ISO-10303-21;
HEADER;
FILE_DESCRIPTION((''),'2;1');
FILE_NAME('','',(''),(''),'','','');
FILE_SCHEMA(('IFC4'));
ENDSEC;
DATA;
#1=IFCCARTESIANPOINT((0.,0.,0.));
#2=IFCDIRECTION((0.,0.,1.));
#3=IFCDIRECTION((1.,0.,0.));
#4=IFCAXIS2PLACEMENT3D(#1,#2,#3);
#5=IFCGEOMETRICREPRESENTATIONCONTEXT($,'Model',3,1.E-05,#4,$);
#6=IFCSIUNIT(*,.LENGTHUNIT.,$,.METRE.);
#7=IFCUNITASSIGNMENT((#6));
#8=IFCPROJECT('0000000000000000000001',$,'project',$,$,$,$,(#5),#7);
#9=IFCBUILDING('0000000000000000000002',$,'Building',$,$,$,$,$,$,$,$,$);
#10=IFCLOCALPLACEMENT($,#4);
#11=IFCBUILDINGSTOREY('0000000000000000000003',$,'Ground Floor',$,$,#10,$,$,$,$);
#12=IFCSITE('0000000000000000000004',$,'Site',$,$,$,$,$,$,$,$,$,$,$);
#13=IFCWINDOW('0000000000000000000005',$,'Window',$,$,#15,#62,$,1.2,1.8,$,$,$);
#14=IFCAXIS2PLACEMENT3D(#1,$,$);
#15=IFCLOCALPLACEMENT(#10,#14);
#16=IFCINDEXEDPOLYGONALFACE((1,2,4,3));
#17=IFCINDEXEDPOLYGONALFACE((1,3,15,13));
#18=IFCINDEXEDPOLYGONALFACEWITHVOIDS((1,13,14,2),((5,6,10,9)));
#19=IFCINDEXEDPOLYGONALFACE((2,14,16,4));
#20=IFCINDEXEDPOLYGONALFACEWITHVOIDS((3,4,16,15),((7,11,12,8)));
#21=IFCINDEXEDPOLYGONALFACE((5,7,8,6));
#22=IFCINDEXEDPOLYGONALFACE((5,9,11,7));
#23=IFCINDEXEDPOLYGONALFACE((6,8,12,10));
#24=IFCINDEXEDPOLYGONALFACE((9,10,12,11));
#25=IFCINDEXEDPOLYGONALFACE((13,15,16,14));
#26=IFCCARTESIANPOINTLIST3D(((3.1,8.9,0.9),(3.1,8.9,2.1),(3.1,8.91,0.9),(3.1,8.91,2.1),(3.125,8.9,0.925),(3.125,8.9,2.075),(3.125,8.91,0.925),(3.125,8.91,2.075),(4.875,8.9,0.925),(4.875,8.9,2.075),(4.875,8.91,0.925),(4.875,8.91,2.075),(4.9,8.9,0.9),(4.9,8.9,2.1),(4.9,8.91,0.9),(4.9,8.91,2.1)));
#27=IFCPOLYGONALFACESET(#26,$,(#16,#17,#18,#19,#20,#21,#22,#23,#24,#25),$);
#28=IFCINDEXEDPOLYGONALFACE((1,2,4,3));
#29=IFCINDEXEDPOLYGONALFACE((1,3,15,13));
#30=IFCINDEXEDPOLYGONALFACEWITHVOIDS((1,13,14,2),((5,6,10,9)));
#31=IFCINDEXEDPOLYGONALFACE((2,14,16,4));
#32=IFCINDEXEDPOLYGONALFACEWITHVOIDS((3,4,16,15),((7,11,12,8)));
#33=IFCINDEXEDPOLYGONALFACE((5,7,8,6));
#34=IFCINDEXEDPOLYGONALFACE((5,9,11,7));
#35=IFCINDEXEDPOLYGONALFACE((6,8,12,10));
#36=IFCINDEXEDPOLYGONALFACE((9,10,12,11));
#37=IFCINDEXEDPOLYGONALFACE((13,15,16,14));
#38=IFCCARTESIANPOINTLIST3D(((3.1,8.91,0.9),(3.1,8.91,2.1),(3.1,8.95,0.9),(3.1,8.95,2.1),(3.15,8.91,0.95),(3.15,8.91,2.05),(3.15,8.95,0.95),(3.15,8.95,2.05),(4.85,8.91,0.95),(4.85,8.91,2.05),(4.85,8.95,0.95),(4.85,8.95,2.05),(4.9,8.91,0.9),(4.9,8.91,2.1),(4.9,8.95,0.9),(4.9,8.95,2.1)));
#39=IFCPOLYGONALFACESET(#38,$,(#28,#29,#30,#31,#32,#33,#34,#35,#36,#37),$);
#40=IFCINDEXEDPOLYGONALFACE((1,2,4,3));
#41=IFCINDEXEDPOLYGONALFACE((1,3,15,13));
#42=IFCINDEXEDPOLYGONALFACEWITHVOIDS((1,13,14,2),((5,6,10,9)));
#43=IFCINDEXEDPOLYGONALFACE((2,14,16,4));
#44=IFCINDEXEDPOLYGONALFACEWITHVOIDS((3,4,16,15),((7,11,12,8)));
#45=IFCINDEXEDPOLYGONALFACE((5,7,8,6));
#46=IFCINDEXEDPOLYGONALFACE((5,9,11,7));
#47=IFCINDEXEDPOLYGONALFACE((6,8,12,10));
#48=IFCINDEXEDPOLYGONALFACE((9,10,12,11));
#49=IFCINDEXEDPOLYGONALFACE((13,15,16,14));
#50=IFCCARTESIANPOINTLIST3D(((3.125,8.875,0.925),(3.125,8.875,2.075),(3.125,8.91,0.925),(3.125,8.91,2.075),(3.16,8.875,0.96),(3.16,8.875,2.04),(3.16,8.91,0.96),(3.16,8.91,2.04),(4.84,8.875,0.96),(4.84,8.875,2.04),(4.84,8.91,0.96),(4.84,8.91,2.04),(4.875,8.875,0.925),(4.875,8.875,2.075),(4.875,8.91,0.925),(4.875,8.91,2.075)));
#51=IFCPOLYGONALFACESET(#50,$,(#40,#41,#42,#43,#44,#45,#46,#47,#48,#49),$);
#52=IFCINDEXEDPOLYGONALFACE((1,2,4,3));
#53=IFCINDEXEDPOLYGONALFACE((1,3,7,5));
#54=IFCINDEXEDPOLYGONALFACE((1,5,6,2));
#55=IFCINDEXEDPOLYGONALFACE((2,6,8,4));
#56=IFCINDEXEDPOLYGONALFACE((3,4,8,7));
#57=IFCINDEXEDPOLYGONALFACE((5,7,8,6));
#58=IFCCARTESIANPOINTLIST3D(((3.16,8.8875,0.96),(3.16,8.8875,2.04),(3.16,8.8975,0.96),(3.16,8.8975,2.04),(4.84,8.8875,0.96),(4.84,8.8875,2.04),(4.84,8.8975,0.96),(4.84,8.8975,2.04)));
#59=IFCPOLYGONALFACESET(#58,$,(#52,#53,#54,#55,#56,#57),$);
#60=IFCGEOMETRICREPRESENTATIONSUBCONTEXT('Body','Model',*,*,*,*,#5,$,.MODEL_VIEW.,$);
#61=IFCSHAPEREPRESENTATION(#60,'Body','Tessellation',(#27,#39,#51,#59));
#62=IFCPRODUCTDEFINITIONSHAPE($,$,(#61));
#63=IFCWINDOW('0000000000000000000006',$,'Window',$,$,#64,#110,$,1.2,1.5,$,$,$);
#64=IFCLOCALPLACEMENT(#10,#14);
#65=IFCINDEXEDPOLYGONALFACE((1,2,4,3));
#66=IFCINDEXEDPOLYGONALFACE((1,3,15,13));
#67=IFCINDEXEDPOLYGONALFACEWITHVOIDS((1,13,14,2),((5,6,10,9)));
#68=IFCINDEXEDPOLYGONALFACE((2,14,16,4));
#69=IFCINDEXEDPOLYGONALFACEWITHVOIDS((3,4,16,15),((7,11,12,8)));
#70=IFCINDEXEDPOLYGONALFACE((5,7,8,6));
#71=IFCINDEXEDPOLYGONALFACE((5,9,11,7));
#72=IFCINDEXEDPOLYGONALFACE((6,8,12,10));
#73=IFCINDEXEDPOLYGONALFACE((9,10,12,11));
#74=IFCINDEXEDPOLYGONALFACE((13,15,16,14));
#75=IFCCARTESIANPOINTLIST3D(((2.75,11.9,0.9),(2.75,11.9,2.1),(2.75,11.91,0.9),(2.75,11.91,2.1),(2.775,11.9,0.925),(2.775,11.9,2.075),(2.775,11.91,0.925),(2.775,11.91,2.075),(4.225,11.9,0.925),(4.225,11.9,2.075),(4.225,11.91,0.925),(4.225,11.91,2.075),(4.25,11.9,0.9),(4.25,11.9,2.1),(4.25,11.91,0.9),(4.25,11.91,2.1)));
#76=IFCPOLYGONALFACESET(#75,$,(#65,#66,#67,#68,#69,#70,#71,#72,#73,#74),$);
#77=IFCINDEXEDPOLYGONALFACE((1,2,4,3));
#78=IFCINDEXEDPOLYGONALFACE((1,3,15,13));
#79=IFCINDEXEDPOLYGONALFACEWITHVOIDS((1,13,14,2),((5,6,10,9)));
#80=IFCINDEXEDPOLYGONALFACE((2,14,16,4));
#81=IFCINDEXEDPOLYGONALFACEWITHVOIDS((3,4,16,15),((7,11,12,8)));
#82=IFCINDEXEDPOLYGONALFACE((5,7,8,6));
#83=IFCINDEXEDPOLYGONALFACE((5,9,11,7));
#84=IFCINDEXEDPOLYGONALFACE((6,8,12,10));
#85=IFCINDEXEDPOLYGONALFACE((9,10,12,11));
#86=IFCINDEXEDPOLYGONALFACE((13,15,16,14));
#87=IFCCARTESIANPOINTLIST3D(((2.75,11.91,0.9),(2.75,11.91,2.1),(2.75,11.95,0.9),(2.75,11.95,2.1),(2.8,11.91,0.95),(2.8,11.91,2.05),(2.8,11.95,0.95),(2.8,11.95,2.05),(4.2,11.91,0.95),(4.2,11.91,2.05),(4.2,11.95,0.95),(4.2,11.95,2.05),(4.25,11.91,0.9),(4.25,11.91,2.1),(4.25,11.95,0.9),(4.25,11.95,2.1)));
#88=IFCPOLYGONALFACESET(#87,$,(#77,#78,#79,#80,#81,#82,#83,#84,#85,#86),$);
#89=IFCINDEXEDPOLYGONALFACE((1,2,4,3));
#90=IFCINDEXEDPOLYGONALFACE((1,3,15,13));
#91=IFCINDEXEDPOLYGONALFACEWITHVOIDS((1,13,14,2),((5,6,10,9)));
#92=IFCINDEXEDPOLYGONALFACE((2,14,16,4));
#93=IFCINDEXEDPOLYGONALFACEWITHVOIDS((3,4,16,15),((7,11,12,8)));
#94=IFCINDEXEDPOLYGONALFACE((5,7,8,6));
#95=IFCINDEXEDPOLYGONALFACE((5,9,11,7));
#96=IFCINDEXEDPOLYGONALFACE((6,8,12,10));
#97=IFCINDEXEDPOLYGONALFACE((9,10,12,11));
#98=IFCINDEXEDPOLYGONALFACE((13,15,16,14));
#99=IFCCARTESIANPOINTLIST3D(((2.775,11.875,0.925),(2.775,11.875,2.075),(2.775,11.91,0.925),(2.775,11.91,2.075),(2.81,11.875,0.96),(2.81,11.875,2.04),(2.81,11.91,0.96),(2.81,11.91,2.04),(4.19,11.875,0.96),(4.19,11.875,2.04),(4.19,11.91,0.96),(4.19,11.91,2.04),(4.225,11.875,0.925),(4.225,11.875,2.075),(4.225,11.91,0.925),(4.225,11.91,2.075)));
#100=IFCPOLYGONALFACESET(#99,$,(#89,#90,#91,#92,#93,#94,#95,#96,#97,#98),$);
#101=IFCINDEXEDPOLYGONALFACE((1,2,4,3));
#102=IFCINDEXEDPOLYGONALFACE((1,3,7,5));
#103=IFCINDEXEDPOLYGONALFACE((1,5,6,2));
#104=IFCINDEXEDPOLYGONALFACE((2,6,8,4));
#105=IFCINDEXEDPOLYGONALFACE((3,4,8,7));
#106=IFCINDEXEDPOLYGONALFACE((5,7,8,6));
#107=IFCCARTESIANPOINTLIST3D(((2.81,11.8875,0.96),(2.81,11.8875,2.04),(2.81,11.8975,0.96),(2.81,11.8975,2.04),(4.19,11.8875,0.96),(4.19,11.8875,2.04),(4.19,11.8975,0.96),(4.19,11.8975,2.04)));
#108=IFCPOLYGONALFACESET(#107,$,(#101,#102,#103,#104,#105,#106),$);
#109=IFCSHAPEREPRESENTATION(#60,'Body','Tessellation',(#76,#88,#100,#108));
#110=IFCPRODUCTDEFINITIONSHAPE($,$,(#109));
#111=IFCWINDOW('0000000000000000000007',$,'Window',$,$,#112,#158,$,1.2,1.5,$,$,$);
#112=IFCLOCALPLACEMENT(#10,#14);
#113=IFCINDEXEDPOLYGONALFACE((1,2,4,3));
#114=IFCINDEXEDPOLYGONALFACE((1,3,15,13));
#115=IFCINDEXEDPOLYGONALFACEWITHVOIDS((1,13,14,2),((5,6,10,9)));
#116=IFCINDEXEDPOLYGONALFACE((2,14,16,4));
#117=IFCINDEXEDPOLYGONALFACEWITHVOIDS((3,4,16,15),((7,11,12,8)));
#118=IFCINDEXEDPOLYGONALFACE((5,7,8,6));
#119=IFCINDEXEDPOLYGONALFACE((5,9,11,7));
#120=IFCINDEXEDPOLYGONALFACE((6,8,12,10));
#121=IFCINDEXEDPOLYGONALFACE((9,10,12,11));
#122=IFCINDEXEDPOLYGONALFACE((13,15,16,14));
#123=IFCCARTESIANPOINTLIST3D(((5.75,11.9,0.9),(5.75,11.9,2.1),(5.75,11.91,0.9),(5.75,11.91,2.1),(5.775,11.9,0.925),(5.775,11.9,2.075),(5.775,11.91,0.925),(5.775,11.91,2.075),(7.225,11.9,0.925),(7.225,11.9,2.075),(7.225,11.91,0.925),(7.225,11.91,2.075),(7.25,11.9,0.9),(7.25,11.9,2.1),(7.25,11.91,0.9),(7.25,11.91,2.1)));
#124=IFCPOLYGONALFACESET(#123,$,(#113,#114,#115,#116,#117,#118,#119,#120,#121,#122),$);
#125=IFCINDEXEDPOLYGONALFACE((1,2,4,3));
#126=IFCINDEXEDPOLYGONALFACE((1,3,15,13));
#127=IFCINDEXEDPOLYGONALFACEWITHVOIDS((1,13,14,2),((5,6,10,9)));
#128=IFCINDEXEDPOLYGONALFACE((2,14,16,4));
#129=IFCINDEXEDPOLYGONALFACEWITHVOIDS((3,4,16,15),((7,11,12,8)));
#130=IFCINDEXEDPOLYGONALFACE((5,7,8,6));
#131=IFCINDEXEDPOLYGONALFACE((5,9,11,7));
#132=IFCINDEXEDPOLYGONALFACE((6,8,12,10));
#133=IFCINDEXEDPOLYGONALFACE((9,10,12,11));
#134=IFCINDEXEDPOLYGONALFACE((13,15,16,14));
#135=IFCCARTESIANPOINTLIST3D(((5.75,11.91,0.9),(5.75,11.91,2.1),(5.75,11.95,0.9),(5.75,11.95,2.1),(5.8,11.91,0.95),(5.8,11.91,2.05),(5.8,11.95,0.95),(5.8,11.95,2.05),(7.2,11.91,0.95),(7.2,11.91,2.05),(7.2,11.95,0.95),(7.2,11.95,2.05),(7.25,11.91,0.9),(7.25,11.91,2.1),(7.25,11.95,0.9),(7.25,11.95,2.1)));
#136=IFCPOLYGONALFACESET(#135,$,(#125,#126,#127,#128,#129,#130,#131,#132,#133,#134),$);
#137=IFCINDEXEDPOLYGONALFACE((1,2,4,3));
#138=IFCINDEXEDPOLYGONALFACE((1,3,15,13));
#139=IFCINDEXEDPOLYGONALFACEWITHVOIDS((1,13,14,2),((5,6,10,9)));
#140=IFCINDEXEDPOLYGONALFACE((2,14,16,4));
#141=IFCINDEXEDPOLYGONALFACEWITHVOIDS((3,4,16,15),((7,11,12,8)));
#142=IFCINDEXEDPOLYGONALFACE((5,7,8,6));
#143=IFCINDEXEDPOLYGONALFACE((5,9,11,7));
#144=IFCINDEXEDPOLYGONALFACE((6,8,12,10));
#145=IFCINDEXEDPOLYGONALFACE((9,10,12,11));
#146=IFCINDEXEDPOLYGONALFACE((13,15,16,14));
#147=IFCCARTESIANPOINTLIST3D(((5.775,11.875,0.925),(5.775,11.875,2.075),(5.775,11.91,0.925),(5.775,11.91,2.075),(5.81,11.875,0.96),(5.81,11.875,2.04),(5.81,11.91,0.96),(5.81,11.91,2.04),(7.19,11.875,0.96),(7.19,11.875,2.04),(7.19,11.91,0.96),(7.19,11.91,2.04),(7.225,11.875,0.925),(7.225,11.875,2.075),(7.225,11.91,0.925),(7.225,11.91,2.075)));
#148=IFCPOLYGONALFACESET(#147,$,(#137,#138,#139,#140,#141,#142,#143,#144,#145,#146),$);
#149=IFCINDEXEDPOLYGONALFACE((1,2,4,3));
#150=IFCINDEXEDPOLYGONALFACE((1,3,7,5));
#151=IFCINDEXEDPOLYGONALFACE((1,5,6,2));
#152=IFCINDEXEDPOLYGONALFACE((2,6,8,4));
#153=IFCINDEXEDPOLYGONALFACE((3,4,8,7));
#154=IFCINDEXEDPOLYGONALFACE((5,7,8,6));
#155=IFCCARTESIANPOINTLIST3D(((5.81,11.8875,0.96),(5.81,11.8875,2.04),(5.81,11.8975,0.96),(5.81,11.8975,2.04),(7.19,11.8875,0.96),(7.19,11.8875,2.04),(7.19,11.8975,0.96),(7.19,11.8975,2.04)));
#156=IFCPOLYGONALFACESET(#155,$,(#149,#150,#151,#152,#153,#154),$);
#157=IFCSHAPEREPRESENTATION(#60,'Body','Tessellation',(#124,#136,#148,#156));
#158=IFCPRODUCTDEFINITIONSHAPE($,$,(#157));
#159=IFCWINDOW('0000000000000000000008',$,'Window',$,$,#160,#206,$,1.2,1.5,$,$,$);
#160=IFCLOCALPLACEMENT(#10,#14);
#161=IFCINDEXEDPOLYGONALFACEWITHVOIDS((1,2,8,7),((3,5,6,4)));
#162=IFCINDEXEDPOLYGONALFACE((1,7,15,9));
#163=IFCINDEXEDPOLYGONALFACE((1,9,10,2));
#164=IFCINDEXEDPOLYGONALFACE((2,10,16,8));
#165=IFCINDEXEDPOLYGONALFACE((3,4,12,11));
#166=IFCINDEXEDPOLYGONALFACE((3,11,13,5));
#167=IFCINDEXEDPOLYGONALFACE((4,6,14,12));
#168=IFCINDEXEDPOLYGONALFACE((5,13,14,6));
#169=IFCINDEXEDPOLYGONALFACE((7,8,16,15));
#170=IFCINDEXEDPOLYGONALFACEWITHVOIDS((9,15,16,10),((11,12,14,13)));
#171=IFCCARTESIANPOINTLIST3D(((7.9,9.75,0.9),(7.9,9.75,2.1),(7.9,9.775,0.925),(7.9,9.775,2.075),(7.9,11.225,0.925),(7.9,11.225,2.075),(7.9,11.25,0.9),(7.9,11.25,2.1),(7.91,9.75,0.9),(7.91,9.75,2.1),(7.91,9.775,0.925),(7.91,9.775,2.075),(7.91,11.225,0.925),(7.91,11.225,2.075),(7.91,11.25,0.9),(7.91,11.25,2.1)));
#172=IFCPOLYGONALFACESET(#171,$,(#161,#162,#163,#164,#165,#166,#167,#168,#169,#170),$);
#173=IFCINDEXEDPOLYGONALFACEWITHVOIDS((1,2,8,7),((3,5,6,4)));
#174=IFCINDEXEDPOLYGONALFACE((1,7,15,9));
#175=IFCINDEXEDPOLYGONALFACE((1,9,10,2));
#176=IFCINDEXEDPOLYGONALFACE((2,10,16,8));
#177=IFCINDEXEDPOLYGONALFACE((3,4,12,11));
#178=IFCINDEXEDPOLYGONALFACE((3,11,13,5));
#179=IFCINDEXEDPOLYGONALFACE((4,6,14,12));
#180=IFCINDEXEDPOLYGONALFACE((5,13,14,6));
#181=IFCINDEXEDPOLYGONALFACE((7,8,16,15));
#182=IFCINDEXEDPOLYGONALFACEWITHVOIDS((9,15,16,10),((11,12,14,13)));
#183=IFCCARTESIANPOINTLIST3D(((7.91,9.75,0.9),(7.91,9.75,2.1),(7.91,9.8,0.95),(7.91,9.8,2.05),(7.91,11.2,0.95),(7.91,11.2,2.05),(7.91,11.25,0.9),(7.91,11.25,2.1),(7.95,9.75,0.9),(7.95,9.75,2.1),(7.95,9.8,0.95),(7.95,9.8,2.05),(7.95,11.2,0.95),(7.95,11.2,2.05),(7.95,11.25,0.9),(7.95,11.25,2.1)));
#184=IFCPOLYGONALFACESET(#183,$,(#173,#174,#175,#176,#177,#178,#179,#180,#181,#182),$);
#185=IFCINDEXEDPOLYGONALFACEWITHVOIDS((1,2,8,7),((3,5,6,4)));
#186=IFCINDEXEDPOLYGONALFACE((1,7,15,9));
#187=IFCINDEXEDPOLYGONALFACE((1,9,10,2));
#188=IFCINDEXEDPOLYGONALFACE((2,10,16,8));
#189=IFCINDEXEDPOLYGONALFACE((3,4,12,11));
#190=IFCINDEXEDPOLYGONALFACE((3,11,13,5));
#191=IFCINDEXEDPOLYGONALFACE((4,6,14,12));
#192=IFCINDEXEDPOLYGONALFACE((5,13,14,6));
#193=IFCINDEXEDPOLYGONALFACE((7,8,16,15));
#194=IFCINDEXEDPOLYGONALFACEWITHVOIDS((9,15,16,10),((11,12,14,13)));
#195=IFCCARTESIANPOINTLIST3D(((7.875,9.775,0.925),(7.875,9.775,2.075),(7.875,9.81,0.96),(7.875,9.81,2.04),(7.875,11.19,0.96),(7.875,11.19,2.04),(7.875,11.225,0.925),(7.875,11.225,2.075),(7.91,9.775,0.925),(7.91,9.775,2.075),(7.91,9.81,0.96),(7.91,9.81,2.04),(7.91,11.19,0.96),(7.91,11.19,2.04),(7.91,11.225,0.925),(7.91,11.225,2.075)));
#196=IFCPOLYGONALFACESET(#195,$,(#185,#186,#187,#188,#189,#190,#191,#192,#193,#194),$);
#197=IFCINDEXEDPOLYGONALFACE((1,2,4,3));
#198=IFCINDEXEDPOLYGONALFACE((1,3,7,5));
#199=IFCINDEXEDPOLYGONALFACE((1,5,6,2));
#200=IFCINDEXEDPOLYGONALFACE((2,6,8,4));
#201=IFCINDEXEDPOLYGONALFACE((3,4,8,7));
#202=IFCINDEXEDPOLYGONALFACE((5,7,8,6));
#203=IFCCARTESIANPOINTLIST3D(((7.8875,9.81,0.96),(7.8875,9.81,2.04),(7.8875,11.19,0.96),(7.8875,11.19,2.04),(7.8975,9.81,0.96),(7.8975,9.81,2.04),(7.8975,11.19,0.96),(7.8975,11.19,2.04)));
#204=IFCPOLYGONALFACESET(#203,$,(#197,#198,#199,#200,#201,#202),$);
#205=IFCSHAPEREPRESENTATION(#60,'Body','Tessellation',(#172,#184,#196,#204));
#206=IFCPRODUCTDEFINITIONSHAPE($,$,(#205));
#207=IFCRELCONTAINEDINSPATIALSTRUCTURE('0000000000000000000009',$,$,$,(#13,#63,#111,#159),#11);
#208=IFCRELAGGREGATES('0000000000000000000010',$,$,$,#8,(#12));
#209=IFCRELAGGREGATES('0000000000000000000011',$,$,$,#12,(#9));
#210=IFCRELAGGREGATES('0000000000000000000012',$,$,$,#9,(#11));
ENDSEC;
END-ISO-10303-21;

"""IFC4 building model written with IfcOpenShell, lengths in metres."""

from ifc_helpers import new_model, si_unit, frame, origin_with_axes, place, context, subcontext, project, spatial, line, indexed_curve, outline, extrude, element, save


model = new_model("IFC4")

# Units and contexts
model_context = context("Model", 3, precision=1e-05, world=origin_with_axes())
body_context = subcontext(model_context, "Body", "Model", "MODEL_VIEW")
ifc_project = project(units=[si_unit("LENGTHUNIT", "METRE")], contexts=[model_context])

# Site, building, storey
site = spatial("IfcSite", under=ifc_project, Name="Site")
building = spatial("IfcBuilding", under=site, Name="Building")
storey_placement = place(None, origin_with_axes())
storey = spatial("IfcBuildingStorey", under=building, at=storey_placement, Name="Ground Floor")

# Windows
window_1_placement = place(storey_placement, frame((4.9, 9.0, 0.9), z_axis=(0.0, 0.0, 1.0), x_axis=(-1.0, 0.0, 0.0)))
element("IfcWindow", 1, at=window_1_placement, inside=storey, Name="Window", OverallHeight=1.2, OverallWidth=1.8, context=body_context, shape_type="SweptSolid", body=[
    extrude(outline(indexed_curve([(0.0, 0.0), (1.8, 0.0), (1.8, 1.2), (0.0, 1.2)], segments=[line(1, 2, 3, 4, 1)]), holes=[indexed_curve([(0.025, 0.025), (1.775, 0.025), (1.775, 1.175), (0.025, 1.175)], segments=[line(1, 2, 3, 4, 1)])]), frame((0.0, 0.09, 0.0), z_axis=(0.0, -1.0, 0.0), x_axis=(1.0, 0.0, 0.0)), (0.0, 0.0, -1.0), 0.01),
    extrude(outline(indexed_curve([(0.0, 0.0), (1.8, 0.0), (1.8, 1.2), (0.0, 1.2)], segments=[line(1, 2, 3, 4, 1)]), holes=[indexed_curve([(0.05, 0.05), (1.75, 0.05), (1.75, 1.15), (0.05, 1.15)], segments=[line(1, 2, 3, 4, 1)])]), frame((0.0, 0.05, 0.0), z_axis=(0.0, -1.0, 0.0), x_axis=(1.0, 0.0, 0.0)), (0.0, 0.0, -1.0), 0.04),
    extrude(outline(indexed_curve([(0.0, 0.0), (1.75, 0.0), (1.75, 1.15), (0.0, 1.15)], segments=[line(1, 2, 3, 4, 1)]), holes=[indexed_curve([(0.035, 0.035), (1.715, 0.035), (1.715, 1.115), (0.035, 1.115)], segments=[line(1, 2, 3, 4, 1)])]), frame((0.025, 0.09, 0.025), z_axis=(0.0, -1.0, 0.0), x_axis=(1.0, 0.0, 0.0)), (0.0, 0.0, -1.0), 0.035),
    extrude(outline(indexed_curve([(0.035, 0.035), (1.715, 0.035), (1.715, 1.115), (0.035, 1.115)], segments=[line(1, 2, 3, 4, 1)])), frame((0.025, 0.1025, 0.025), z_axis=(0.0, -1.0, 0.0), x_axis=(1.0, 0.0, 0.0)), (0.0, 0.0, -1.0), 0.01),
])
for number, where, z_axis, x_axis, name in (
    (2, (4.25, 12.0, 0.9), (0.0, 0.0, 1.0), (-1.0, 0.0, 0.0), "Window"),
    (3, (7.25, 12.0, 0.9), (0.0, 0.0, 1.0), (-1.0, 0.0, 0.0), "Window"),
    (4, (8.0, 9.75, 0.9), (0.0, 0.0, 1.0), (0.0, 1.0, 0.0), "Window"),
):
    element("IfcWindow", number, at=place(storey_placement, frame(where, z_axis=z_axis, x_axis=x_axis)), inside=storey, Name=name, OverallHeight=1.2, OverallWidth=1.5, context=body_context, shape_type="SweptSolid", body=[
        extrude(outline(indexed_curve([(0.0, 0.0), (1.5, 0.0), (1.5, 1.2), (0.0, 1.2)], segments=[line(1, 2, 3, 4, 1)]), holes=[indexed_curve([(0.025, 0.025), (1.475, 0.025), (1.475, 1.175), (0.025, 1.175)], segments=[line(1, 2, 3, 4, 1)])]), frame((0.0, 0.09, 0.0), z_axis=(0.0, -1.0, 0.0), x_axis=(1.0, 0.0, 0.0)), (0.0, 0.0, -1.0), 0.01),
        extrude(outline(indexed_curve([(0.0, 0.0), (1.5, 0.0), (1.5, 1.2), (0.0, 1.2)], segments=[line(1, 2, 3, 4, 1)]), holes=[indexed_curve([(0.05, 0.05), (1.45, 0.05), (1.45, 1.15), (0.05, 1.15)], segments=[line(1, 2, 3, 4, 1)])]), frame((0.0, 0.05, 0.0), z_axis=(0.0, -1.0, 0.0), x_axis=(1.0, 0.0, 0.0)), (0.0, 0.0, -1.0), 0.04),
        extrude(outline(indexed_curve([(0.0, 0.0), (1.45, 0.0), (1.45, 1.15), (0.0, 1.15)], segments=[line(1, 2, 3, 4, 1)]), holes=[indexed_curve([(0.035, 0.035), (1.415, 0.035), (1.415, 1.115), (0.035, 1.115)], segments=[line(1, 2, 3, 4, 1)])]), frame((0.025, 0.09, 0.025), z_axis=(0.0, -1.0, 0.0), x_axis=(1.0, 0.0, 0.0)), (0.0, 0.0, -1.0), 0.035),
        extrude(outline(indexed_curve([(0.035, 0.035), (1.415, 0.035), (1.415, 1.115), (0.035, 1.115)], segments=[line(1, 2, 3, 4, 1)])), frame((0.025, 0.1025, 0.025), z_axis=(0.0, -1.0, 0.0), x_axis=(1.0, 0.0, 0.0)), (0.0, 0.0, -1.0), 0.01),
    ])

save(model, "model.ifc")
